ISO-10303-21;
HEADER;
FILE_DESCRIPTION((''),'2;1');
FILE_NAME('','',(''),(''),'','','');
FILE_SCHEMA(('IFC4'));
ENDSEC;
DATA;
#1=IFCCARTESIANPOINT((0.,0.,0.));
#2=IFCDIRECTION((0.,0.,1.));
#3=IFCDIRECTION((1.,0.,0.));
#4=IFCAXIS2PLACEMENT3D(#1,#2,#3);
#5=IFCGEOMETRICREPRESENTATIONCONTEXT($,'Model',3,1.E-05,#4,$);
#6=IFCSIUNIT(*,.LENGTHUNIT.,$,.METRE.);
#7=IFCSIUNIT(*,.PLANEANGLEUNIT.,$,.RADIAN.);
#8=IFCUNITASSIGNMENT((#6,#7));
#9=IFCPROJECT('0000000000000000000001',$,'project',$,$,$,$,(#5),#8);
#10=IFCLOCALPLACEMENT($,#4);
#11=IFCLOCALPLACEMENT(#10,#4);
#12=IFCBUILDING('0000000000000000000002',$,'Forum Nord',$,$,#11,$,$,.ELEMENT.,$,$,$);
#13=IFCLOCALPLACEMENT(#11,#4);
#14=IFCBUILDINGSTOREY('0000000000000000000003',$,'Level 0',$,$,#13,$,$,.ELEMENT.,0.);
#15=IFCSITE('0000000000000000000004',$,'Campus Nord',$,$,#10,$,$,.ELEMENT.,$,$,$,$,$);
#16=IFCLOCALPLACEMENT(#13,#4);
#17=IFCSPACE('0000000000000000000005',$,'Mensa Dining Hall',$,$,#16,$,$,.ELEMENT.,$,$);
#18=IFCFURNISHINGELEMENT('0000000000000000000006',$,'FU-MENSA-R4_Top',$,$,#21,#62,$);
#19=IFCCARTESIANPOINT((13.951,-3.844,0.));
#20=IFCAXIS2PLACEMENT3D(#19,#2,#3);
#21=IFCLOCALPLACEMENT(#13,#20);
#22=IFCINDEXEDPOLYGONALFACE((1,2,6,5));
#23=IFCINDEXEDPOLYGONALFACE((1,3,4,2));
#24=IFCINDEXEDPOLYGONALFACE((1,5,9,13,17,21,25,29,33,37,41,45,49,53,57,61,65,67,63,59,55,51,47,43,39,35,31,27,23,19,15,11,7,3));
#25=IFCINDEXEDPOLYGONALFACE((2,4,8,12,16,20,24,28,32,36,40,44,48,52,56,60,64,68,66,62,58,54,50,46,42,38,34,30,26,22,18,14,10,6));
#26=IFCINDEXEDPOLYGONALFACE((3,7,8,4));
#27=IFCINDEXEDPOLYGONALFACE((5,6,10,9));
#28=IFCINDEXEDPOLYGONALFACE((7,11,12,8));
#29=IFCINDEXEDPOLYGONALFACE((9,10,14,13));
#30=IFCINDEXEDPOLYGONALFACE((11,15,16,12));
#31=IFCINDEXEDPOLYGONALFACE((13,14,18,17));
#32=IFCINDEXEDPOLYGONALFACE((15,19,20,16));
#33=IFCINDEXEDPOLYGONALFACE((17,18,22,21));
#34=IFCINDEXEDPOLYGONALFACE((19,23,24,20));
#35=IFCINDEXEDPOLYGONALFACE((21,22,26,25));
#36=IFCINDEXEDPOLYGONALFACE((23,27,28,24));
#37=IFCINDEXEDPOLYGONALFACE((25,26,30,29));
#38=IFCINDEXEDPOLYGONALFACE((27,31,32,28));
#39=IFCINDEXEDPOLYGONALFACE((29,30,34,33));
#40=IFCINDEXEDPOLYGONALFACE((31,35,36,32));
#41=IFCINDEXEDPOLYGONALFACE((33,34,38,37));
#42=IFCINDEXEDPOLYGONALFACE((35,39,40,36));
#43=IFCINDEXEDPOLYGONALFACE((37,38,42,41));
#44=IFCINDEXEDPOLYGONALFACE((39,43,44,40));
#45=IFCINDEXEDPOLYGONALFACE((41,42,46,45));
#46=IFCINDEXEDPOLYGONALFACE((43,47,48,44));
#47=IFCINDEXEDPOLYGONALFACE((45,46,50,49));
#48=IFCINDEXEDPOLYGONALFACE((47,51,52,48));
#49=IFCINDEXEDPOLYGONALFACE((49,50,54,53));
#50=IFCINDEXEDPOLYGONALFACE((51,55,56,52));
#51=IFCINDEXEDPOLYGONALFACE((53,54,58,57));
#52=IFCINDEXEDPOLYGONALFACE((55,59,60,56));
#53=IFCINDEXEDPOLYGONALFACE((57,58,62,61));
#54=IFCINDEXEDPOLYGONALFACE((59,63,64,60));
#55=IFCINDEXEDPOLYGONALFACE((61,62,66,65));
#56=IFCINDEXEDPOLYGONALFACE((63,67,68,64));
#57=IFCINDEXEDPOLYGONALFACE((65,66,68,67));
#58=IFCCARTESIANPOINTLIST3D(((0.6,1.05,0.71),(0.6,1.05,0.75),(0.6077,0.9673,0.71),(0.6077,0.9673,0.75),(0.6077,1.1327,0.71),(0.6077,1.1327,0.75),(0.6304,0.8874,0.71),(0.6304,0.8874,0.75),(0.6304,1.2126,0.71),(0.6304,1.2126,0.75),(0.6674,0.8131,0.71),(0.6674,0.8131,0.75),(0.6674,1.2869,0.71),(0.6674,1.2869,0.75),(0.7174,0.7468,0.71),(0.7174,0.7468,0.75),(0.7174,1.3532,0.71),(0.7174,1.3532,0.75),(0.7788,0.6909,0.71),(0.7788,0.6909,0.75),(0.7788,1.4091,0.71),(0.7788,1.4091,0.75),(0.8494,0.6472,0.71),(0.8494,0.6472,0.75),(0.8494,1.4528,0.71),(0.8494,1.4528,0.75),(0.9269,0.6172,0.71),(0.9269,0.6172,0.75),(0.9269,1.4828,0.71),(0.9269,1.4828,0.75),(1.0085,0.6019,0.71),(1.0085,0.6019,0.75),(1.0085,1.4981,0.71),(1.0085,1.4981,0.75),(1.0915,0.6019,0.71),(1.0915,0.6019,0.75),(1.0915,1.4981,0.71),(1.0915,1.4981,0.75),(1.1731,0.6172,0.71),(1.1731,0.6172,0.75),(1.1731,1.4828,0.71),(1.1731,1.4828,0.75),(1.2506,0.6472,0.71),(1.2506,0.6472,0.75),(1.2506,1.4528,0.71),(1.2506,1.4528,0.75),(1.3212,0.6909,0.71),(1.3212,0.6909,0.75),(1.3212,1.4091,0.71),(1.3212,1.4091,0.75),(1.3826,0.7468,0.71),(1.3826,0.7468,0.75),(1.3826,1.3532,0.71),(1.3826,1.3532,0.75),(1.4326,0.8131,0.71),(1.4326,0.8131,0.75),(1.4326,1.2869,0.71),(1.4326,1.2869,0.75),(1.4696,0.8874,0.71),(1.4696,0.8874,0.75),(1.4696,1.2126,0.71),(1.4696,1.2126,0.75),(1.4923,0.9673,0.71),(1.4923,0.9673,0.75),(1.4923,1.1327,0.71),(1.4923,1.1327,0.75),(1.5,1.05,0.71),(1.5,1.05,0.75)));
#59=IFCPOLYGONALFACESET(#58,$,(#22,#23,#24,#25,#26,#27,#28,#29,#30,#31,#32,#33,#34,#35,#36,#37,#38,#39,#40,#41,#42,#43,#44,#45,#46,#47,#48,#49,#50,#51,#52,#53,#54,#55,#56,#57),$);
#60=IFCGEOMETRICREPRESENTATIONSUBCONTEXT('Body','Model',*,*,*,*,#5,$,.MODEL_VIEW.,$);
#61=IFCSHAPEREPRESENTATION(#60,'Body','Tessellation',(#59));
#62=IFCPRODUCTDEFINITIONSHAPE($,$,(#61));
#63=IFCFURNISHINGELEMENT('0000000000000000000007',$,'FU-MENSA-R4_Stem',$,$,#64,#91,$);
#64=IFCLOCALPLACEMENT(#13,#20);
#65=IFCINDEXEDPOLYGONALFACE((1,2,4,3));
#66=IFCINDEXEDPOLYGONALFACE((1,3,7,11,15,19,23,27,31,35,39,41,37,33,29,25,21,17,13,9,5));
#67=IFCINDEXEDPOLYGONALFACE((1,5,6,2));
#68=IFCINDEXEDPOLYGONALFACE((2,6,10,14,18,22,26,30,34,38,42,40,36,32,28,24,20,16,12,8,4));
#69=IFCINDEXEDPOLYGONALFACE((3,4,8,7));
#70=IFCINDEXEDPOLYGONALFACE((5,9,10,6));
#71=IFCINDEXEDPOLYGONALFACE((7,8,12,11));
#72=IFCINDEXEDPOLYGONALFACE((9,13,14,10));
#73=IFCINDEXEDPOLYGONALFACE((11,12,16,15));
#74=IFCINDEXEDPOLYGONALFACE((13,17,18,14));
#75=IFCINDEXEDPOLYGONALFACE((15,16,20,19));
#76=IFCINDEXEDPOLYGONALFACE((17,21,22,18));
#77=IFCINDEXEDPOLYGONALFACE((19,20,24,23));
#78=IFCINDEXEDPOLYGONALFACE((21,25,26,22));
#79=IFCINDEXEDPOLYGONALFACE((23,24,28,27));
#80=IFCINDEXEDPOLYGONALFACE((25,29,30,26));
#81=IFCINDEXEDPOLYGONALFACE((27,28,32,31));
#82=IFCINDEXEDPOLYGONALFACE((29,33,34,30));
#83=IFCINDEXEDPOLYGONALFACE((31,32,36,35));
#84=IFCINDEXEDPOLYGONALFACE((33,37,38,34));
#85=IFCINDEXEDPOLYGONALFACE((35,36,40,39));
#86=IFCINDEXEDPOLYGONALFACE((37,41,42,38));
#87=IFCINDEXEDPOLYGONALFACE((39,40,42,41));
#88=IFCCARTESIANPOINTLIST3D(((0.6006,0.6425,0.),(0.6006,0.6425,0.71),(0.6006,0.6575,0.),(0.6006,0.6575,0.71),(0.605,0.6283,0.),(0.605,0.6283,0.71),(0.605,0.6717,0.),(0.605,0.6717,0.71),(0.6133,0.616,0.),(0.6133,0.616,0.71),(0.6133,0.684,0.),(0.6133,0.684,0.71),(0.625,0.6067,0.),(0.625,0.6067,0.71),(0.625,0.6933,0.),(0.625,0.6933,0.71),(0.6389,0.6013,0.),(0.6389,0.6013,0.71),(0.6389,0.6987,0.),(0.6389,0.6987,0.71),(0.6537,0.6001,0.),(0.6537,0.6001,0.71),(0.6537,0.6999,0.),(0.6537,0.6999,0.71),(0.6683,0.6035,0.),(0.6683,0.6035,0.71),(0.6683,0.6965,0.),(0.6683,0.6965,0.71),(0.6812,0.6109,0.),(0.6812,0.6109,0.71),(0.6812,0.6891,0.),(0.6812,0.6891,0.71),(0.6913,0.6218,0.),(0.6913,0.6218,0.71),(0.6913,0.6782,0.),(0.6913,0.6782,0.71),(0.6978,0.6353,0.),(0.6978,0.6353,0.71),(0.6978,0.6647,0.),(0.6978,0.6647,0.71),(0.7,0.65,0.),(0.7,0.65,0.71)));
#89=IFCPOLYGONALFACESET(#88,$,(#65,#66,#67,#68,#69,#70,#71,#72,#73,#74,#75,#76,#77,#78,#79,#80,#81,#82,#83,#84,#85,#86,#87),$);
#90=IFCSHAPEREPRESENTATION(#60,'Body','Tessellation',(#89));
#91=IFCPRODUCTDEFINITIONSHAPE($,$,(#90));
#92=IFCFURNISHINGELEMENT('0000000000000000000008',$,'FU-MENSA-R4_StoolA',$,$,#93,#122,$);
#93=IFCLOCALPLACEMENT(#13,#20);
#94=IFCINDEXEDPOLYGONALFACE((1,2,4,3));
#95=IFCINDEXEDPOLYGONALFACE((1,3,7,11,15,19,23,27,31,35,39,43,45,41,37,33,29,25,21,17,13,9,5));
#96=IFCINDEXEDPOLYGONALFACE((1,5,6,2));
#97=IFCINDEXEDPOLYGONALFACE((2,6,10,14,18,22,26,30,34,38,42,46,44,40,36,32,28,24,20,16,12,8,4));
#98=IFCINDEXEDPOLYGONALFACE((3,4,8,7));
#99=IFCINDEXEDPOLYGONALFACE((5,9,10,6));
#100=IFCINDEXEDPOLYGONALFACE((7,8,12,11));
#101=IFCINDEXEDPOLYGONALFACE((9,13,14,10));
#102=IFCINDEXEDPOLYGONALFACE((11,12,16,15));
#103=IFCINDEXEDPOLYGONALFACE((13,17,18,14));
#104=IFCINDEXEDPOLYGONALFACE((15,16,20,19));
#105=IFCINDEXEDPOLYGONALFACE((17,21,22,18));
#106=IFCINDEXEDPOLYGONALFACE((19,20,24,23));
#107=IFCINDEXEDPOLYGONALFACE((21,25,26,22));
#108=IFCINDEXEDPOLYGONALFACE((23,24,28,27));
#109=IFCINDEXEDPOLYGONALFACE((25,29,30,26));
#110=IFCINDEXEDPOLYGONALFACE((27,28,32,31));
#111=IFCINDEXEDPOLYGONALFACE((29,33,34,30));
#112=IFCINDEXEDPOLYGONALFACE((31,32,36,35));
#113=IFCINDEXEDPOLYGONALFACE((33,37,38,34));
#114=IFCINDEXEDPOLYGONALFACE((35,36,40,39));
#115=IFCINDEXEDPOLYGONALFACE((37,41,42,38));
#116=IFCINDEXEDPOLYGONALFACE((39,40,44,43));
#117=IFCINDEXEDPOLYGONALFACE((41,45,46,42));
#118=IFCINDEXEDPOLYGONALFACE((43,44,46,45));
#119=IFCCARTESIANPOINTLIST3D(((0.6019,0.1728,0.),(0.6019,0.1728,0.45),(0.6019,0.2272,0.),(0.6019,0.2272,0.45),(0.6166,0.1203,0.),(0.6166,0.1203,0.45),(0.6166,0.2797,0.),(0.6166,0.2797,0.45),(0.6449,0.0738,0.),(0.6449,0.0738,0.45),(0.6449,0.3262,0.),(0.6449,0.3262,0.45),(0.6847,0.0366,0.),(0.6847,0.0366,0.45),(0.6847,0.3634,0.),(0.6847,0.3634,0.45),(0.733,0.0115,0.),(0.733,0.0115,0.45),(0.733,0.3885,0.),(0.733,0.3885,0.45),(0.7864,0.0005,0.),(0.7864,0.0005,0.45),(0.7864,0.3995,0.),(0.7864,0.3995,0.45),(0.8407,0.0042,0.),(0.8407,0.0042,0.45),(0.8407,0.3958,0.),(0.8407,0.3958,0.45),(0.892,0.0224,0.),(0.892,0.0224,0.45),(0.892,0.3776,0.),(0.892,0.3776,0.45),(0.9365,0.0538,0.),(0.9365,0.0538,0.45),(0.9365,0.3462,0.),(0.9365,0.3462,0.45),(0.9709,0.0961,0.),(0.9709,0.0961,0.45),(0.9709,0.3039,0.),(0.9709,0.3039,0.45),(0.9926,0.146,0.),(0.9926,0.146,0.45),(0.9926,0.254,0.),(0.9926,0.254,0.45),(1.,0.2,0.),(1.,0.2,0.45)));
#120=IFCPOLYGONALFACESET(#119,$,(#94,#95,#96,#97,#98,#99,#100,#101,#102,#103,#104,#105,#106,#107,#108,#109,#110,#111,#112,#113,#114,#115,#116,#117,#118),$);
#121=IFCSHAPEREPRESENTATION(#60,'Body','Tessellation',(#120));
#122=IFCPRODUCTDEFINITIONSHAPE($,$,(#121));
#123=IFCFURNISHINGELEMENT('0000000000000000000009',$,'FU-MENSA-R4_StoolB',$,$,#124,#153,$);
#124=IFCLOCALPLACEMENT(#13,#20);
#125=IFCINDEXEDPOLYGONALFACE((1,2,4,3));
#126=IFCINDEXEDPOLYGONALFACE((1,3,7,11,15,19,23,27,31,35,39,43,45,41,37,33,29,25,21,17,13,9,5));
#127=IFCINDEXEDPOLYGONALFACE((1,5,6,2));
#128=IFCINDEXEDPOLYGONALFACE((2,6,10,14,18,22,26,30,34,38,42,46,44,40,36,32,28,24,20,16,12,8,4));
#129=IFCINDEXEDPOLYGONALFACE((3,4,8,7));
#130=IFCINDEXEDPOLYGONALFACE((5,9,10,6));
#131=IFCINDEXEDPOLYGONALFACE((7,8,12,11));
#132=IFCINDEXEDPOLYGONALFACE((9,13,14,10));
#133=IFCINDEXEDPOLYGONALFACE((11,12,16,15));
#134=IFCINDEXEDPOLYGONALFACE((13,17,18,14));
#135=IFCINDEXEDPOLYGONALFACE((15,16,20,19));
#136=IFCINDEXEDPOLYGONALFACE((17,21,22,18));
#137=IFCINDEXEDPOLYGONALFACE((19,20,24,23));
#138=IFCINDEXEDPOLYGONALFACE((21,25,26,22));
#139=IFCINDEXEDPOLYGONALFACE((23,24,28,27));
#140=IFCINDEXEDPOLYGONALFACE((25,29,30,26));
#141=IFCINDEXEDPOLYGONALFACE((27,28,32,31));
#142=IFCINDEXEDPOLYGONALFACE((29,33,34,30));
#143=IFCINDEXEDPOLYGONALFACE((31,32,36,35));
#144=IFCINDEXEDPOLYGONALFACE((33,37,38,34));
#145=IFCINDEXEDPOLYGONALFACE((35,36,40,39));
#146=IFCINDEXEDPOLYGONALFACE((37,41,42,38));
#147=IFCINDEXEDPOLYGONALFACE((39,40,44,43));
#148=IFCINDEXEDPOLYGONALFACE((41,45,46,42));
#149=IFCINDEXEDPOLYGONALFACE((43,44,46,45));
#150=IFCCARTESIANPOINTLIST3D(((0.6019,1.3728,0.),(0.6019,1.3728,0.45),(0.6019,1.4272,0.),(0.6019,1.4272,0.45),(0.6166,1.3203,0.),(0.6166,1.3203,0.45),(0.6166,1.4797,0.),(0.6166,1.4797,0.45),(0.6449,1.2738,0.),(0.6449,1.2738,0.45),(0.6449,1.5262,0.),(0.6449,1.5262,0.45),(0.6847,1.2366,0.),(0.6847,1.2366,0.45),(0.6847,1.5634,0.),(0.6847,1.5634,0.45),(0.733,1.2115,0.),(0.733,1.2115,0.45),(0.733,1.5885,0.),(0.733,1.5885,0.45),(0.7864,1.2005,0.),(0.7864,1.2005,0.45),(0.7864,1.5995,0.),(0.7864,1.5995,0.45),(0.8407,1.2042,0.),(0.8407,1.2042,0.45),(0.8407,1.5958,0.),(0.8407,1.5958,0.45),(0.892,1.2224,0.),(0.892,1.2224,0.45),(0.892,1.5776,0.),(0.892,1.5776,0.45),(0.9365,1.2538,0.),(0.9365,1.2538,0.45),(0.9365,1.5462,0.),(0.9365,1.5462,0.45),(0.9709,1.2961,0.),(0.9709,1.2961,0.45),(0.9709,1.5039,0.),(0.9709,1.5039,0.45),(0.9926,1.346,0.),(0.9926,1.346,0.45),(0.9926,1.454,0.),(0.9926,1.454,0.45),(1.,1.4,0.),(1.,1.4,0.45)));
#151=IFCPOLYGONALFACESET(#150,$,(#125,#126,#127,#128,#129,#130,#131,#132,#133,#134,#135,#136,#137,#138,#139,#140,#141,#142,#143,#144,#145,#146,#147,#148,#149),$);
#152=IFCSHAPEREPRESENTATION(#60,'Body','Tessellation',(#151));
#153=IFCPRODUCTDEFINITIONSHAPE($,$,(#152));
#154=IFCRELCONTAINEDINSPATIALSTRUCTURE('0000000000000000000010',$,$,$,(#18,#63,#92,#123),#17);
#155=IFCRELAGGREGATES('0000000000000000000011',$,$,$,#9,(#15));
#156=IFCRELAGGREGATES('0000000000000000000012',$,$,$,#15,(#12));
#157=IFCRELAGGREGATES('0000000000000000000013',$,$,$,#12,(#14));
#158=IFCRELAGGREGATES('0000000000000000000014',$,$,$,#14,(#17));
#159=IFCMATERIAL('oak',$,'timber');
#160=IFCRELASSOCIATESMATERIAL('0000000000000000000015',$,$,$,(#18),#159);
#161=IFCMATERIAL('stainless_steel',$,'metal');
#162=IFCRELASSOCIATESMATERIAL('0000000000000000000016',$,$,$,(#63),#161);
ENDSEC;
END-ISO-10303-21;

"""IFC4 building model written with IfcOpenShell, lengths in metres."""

from ifc_helpers import new_model, si_unit, frame, frame_2d, origin_with_axes, place, context, subcontext, project, spatial, circle, extrude, material, element, save


model = new_model("IFC4")

# Units and contexts
model_context = context("Model", 3, precision=1e-05, world=origin_with_axes())
body_context = subcontext(model_context, "Body", "Model", "MODEL_VIEW")
ifc_project = project(units=[si_unit("LENGTHUNIT", "METRE"), si_unit("PLANEANGLEUNIT", "RADIAN")], contexts=[model_context])

# Site, building, storey
site_placement = place(None, origin_with_axes())
site = spatial("IfcSite", under=ifc_project, at=site_placement, Name="Campus Nord", CompositionType="ELEMENT")
building_placement = place(site_placement, origin_with_axes())
building = spatial("IfcBuilding", under=site, at=building_placement, Name="Forum Nord", CompositionType="ELEMENT")
storey_placement = place(building_placement, origin_with_axes())
storey = spatial("IfcBuildingStorey", under=building, at=storey_placement, Name="Level 0", CompositionType="ELEMENT", Elevation=0.0)

# Shared definitions
space_placement = place(storey_placement, origin_with_axes())
space = spatial("IfcSpace", under=storey, at=space_placement, Name="Mensa Dining Hall", CompositionType="ELEMENT")

# Furnishing elements
ifc_material_1 = material(Name="oak", Category="timber")
furnishing_1_placement = place(storey_placement, frame((13.951, -3.844, 0.0), z_axis=(0.0, 0.0, 1.0), x_axis=(1.0, 0.0, 0.0)))
element("IfcFurnishingElement", 1, at=furnishing_1_placement, inside=space, material=ifc_material_1, Name="FU-MENSA-R4_Top", context=body_context, shape_type="SweptSolid", body=[
    extrude(circle(Radius=0.45, at=frame_2d((1.05, 1.05), x_axis=(1.0, 0.0))), frame((0.0, 0.0, 0.71), z_axis=(0.0, 0.0, 1.0), x_axis=(1.0, 0.0, 0.0)), (0.0, 0.0, 1.0), 0.04),
])
ifc_material_2 = material(Name="stainless_steel", Category="metal")
furnishing_2_placement = place(storey_placement, frame((13.951, -3.844, 0.0), z_axis=(0.0, 0.0, 1.0), x_axis=(1.0, 0.0, 0.0)))
element("IfcFurnishingElement", 2, at=furnishing_2_placement, inside=space, material=ifc_material_2, Name="FU-MENSA-R4_Stem", context=body_context, shape_type="SweptSolid", body=[
    extrude(circle(Radius=0.05, at=frame_2d((0.65, 0.65), x_axis=(1.0, 0.0))), origin_with_axes(), (0.0, 0.0, 1.0), 0.71),
])
furnishing_3_placement = place(storey_placement, frame((13.951, -3.844, 0.0), z_axis=(0.0, 0.0, 1.0), x_axis=(1.0, 0.0, 0.0)))
element("IfcFurnishingElement", 3, at=furnishing_3_placement, inside=space, Name="FU-MENSA-R4_StoolA", context=body_context, shape_type="SweptSolid", body=[
    extrude(circle(Radius=0.2, at=frame_2d((0.8, 0.2), x_axis=(1.0, 0.0))), origin_with_axes(), (0.0, 0.0, 1.0), 0.45),
])
furnishing_4_placement = place(storey_placement, frame((13.951, -3.844, 0.0), z_axis=(0.0, 0.0, 1.0), x_axis=(1.0, 0.0, 0.0)))
element("IfcFurnishingElement", 4, at=furnishing_4_placement, inside=space, Name="FU-MENSA-R4_StoolB", context=body_context, shape_type="SweptSolid", body=[
    extrude(circle(Radius=0.2, at=frame_2d((0.8, 1.4), x_axis=(1.0, 0.0))), origin_with_axes(), (0.0, 0.0, 1.0), 0.45),
])

save(model, "model.ifc")
